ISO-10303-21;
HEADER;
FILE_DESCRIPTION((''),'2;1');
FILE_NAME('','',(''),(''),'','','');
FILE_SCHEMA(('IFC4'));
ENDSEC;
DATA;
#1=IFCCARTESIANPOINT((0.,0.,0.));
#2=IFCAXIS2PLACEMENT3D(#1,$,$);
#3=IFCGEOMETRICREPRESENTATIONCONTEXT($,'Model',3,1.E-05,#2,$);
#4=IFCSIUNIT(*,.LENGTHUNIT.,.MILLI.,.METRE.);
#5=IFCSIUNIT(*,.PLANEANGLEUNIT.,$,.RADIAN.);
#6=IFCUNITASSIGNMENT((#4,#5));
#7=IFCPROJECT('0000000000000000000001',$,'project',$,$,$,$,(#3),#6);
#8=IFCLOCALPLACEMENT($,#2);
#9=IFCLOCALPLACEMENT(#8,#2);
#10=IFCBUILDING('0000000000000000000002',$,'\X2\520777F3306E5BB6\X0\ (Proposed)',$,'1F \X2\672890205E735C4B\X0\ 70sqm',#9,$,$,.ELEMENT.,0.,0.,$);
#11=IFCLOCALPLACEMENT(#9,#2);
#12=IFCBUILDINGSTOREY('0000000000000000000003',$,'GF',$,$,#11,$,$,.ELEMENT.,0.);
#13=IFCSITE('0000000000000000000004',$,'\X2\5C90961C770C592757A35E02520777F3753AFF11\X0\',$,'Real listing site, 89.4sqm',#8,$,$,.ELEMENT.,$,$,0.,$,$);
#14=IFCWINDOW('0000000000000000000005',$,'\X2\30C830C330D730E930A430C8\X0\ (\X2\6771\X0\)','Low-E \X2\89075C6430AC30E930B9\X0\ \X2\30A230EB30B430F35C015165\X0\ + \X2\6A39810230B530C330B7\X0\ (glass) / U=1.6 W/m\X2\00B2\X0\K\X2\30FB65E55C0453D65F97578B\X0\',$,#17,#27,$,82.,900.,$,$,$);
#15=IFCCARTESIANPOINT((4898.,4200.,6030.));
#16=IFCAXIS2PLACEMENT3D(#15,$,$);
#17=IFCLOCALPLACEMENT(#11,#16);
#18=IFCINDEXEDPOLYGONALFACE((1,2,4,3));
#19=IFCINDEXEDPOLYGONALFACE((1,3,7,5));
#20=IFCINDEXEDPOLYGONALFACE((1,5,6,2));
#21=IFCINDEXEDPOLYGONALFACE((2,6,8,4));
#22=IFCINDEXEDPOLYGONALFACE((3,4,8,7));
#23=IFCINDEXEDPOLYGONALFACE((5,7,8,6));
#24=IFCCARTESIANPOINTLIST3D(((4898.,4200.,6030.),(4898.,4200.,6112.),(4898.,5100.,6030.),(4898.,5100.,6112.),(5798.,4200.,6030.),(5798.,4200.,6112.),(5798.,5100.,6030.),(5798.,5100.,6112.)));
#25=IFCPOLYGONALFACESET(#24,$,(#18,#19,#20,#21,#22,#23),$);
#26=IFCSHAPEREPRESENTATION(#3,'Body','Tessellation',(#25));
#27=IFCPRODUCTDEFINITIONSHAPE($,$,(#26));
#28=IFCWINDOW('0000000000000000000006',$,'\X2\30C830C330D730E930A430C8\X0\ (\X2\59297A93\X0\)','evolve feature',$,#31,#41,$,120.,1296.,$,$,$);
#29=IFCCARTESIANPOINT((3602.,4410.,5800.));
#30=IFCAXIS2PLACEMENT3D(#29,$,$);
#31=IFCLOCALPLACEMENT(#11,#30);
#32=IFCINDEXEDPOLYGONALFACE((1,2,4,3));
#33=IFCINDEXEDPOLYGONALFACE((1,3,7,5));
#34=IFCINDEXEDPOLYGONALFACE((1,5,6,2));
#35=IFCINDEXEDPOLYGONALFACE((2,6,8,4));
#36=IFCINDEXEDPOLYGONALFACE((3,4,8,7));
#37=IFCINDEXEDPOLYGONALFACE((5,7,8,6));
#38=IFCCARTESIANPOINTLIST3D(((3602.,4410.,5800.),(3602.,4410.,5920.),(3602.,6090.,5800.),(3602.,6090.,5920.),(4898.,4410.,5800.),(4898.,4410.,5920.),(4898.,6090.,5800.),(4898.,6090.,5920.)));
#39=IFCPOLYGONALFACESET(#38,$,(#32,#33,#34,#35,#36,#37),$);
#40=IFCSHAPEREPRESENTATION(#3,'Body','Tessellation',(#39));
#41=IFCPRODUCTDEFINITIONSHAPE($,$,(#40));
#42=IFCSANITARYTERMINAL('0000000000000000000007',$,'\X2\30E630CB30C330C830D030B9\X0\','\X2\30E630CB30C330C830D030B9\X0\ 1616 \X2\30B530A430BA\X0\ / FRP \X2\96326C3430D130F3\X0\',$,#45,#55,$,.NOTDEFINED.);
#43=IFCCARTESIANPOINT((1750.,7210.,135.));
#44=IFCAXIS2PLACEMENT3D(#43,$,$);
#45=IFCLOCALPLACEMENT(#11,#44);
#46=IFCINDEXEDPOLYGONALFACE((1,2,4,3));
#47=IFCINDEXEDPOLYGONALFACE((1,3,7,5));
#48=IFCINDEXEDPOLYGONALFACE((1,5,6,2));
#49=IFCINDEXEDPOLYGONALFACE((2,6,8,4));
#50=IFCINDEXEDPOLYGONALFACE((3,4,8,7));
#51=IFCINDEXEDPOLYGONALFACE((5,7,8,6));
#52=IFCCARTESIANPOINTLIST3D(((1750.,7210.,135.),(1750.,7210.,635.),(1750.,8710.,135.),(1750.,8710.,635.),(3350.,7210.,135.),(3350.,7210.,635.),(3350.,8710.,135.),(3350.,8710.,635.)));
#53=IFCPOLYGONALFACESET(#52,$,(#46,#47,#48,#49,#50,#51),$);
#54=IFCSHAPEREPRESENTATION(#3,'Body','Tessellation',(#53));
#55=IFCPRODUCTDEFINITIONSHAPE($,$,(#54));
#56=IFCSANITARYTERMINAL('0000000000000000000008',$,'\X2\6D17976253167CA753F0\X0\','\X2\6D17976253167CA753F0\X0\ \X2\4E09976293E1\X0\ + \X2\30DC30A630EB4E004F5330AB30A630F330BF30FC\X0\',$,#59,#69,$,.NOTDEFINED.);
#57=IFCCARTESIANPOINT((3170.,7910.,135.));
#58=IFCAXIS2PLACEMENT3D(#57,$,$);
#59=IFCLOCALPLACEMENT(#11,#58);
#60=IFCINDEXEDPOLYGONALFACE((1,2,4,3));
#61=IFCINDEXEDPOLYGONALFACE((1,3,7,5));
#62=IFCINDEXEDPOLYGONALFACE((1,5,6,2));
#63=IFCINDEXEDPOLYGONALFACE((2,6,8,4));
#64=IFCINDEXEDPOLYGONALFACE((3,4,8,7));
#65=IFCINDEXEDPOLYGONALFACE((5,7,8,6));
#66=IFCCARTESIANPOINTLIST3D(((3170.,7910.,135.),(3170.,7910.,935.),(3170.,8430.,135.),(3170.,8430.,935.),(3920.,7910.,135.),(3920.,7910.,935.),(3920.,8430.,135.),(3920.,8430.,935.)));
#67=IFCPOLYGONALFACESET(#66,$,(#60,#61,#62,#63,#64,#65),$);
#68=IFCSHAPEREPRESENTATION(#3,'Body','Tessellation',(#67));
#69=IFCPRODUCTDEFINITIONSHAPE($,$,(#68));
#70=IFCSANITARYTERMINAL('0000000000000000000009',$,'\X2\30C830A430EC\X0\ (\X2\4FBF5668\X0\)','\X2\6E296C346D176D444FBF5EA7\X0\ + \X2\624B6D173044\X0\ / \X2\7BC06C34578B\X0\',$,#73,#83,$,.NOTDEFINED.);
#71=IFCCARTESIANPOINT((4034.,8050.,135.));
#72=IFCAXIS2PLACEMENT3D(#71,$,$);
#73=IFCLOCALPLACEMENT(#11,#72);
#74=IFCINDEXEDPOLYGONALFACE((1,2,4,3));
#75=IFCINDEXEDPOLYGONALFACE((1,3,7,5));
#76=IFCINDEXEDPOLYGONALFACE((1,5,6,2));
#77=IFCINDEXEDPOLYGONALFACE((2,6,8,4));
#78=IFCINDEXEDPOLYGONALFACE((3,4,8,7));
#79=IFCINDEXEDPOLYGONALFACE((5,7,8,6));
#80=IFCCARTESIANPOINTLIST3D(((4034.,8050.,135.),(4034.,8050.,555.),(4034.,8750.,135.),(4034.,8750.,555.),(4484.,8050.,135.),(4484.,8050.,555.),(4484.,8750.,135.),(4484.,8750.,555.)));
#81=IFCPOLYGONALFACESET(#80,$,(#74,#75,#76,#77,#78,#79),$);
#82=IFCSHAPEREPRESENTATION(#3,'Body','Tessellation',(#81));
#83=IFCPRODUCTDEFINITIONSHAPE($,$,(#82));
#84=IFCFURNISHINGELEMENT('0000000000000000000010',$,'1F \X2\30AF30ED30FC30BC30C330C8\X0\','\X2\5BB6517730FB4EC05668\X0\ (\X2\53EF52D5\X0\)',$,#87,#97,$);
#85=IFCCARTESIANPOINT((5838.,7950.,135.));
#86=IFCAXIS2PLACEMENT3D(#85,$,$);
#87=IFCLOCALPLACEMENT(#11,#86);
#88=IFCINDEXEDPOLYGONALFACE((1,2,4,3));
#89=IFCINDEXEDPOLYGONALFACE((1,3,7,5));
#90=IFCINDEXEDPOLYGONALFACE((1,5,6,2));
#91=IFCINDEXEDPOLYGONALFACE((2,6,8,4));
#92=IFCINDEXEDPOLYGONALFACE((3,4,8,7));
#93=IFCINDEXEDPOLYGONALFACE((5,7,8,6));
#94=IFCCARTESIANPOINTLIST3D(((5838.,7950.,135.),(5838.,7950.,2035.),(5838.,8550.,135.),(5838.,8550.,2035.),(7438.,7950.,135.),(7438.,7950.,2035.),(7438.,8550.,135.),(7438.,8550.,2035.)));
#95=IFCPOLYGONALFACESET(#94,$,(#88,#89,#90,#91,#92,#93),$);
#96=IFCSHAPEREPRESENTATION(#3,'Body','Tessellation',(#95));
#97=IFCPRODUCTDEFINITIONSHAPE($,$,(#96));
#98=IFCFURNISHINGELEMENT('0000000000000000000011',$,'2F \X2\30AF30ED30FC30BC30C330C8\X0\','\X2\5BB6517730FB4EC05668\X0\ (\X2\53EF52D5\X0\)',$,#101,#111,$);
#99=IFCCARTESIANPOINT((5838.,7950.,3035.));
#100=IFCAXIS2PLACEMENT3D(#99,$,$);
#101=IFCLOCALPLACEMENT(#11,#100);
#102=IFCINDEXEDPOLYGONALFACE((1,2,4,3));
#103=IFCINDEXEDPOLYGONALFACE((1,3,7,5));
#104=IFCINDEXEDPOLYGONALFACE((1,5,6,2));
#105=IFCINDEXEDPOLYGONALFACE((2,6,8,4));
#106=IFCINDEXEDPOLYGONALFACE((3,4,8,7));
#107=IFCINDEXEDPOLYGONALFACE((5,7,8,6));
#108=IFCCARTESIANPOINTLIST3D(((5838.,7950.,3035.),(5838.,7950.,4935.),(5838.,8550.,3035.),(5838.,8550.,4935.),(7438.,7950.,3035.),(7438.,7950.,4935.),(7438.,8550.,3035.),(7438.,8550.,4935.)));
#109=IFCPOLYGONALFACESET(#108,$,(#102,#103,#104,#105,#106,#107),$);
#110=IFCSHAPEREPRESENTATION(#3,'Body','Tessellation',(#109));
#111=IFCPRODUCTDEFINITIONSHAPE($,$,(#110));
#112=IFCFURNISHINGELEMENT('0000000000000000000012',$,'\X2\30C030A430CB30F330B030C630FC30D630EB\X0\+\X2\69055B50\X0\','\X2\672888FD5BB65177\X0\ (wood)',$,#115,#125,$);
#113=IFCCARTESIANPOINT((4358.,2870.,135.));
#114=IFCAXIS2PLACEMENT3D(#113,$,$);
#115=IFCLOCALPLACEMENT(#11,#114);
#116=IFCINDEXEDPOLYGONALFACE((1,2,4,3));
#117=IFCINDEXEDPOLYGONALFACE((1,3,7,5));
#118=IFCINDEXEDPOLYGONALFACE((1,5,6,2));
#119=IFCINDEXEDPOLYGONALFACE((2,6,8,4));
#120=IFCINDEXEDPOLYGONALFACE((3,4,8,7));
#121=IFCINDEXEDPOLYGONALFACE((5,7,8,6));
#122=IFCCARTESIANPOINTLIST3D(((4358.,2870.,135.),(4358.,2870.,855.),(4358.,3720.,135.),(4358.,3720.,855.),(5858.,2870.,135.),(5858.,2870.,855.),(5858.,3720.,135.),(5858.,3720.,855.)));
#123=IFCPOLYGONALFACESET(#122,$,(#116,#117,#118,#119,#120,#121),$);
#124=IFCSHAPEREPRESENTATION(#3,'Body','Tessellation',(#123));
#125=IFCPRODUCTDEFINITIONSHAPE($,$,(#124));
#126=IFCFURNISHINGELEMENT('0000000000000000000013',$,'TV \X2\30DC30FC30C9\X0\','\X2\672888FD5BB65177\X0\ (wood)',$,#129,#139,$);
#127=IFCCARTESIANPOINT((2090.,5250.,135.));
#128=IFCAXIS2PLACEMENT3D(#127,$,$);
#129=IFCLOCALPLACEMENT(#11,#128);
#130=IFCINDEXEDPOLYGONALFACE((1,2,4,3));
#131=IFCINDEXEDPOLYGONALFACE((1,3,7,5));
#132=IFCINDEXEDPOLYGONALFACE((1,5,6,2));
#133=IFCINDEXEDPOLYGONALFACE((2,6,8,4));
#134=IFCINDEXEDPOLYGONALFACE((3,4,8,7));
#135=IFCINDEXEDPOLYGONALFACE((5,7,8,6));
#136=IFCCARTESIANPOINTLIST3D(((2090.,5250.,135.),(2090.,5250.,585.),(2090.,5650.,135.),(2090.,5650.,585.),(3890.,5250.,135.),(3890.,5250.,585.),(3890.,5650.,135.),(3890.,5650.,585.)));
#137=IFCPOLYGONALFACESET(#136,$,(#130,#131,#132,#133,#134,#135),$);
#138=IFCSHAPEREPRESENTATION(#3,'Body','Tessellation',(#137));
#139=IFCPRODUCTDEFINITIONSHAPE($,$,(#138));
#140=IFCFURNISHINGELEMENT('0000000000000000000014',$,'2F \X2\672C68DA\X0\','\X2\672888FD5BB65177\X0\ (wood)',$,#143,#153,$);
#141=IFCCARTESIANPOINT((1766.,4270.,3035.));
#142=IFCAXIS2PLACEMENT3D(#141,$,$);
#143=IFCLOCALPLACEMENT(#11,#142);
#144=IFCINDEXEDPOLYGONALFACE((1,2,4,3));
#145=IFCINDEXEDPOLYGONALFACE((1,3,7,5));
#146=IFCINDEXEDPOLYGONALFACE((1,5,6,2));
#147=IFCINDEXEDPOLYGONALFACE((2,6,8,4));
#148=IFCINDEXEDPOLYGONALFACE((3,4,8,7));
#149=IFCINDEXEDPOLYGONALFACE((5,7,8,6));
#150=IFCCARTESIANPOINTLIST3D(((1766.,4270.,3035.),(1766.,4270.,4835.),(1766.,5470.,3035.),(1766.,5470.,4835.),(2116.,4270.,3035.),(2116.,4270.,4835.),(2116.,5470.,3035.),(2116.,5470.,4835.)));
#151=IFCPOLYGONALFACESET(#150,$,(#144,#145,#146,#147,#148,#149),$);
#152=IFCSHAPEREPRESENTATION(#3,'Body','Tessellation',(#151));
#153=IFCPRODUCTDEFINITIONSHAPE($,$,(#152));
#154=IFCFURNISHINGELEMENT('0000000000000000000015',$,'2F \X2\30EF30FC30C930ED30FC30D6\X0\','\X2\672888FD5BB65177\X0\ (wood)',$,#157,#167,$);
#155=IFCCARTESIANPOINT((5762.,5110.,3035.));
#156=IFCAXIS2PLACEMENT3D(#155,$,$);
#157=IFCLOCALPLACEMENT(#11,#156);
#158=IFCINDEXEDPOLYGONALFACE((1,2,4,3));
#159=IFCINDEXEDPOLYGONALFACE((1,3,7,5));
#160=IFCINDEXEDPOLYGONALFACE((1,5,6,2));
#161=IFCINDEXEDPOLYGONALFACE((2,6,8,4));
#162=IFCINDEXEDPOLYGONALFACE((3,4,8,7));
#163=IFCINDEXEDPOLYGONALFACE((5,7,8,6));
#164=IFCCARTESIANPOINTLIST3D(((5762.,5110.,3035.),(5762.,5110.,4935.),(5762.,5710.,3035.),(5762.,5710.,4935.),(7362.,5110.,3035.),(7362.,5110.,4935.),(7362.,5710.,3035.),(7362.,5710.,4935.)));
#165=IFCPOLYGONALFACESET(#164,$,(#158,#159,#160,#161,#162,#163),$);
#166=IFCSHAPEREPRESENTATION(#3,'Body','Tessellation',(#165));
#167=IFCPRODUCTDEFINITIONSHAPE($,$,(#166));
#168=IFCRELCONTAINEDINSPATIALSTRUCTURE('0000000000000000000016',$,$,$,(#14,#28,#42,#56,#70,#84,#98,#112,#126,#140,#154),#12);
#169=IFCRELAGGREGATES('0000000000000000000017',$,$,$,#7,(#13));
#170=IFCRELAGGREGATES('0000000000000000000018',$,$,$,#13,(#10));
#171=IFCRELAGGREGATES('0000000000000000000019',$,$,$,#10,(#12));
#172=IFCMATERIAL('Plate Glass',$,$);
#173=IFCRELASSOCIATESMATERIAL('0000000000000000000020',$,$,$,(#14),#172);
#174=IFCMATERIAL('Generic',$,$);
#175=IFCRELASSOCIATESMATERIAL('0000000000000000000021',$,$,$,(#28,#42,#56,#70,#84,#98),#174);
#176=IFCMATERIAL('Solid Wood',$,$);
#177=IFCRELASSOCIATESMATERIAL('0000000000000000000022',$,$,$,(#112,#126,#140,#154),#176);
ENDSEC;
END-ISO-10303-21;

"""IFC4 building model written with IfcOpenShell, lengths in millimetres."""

from ifc_helpers import new_model, si_unit, frame, frame_2d, origin, place, context, project, spatial, rectangle, extrude, material, element, save


model = new_model("IFC4")

# Units and contexts
model_context = context("Model", 3, precision=1e-05, world=origin())
ifc_project = project(units=[si_unit("LENGTHUNIT", "METRE", prefix="MILLI"), si_unit("PLANEANGLEUNIT", "RADIAN")], contexts=[model_context])

# Site, building, storey
site_placement = place(None, origin())
site = spatial("IfcSite", under=ifc_project, at=site_placement, Name="岐阜県大垣市切石町１", ObjectType="Real listing site, 89.4sqm", CompositionType="ELEMENT", RefElevation=0.0)
building_placement = place(site_placement, origin())
building = spatial("IfcBuilding", under=site, at=building_placement, Name="切石の家 (Proposed)", ObjectType="1F 木造平屋 70sqm", CompositionType="ELEMENT", ElevationOfRefHeight=0.0, ElevationOfTerrain=0.0)
storey_placement = place(building_placement, origin())
storey = spatial("IfcBuildingStorey", under=building, at=storey_placement, Name="GF", CompositionType="ELEMENT", Elevation=0.0)

# Shared definitions
ifc_material_1 = material(Name="Solid Wood")
ifc_material_2 = material(Name="Plate Glass")

# Windows
window_1_placement = place(storey_placement, frame((4898.0, 4200.0, 6030.0)))
element("IfcWindow", 1, at=window_1_placement, inside=storey, material=ifc_material_2, Name="トップライト (東)", Description="Low-E 複層ガラス アルゴン封入 + 樹脂サッシ (glass) / U=1.6 W/m²K・日射取得型", OverallHeight=82.0, OverallWidth=900.0, context=model_context, shape_type="SweptSolid", body=[
    extrude(rectangle(XDim=900.0, YDim=900.0, at=frame_2d((450.0, 450.0))), frame((4898.0, 4200.0, 6030.0)), (0.0, 0.0, 1.0), 82.0),
])
ifc_material_3 = material(Name="Generic")
window_2_placement = place(storey_placement, frame((3602.0, 4410.0, 5800.0)))
element("IfcWindow", 2, at=window_2_placement, inside=storey, material=ifc_material_3, Name="トップライト (天窓)", Description="evolve feature", OverallHeight=120.0, OverallWidth=1296.0, context=model_context, shape_type="SweptSolid", body=[
    extrude(rectangle(XDim=1296.0, YDim=1680.0, at=frame_2d((648.0, 840.0))), frame((3602.0, 4410.0, 5800.0)), (0.0, 0.0, 1.0), 120.0),
])

# Sanitary terminals
sanitary_terminal_1_placement = place(storey_placement, frame((1750.0, 7210.0, 135.0)))
element("IfcSanitaryTerminal", 3, at=sanitary_terminal_1_placement, inside=storey, material=ifc_material_3, Name="ユニットバス", Description="ユニットバス 1616 サイズ / FRP 防水パン", PredefinedType="NOTDEFINED", context=model_context, shape_type="SweptSolid", body=[
    extrude(rectangle(XDim=1600.0, YDim=1500.0, at=frame_2d((800.0, 750.0))), frame((1750.0, 7210.0, 135.0)), (0.0, 0.0, 1.0), 500.0),
])
sanitary_terminal_2_placement = place(storey_placement, frame((3170.0, 7910.0, 135.0)))
element("IfcSanitaryTerminal", 4, at=sanitary_terminal_2_placement, inside=storey, material=ifc_material_3, Name="洗面化粧台", Description="洗面化粧台 三面鏡 + ボウル一体カウンター", PredefinedType="NOTDEFINED", context=model_context, shape_type="SweptSolid", body=[
    extrude(rectangle(XDim=750.0, YDim=520.0, at=frame_2d((375.0, 260.0))), frame((3170.0, 7910.0, 135.0)), (0.0, 0.0, 1.0), 800.0),
])
sanitary_terminal_3_placement = place(storey_placement, frame((4034.0, 8050.0, 135.0)))
element("IfcSanitaryTerminal", 5, at=sanitary_terminal_3_placement, inside=storey, material=ifc_material_3, Name="トイレ (便器)", Description="温水洗浄便座 + 手洗い / 節水型", PredefinedType="NOTDEFINED", context=model_context, shape_type="SweptSolid", body=[
    extrude(rectangle(XDim=450.0, YDim=700.0, at=frame_2d((225.0, 350.0))), frame((4034.0, 8050.0, 135.0)), (0.0, 0.0, 1.0), 420.0),
])

# Furnishing elements
furnishing_1_placement = place(storey_placement, frame((5838.0, 7950.0, 135.0)))
element("IfcFurnishingElement", 6, at=furnishing_1_placement, inside=storey, material=ifc_material_3, Name="1F クローゼット", Description="家具・什器 (可動)", context=model_context, shape_type="SweptSolid", body=[
    extrude(rectangle(XDim=1600.0, YDim=600.0, at=frame_2d((800.0, 300.0))), frame((5838.0, 7950.0, 135.0)), (0.0, 0.0, 1.0), 1900.0),
])
furnishing_2_placement = place(storey_placement, frame((5838.0, 7950.0, 3035.0)))
element("IfcFurnishingElement", 7, at=furnishing_2_placement, inside=storey, material=ifc_material_3, Name="2F クローゼット", Description="家具・什器 (可動)", context=model_context, shape_type="SweptSolid", body=[
    extrude(rectangle(XDim=1600.0, YDim=600.0, at=frame_2d((800.0, 300.0))), frame((5838.0, 7950.0, 3035.0)), (0.0, 0.0, 1.0), 1900.0),
])
furnishing_3_placement = place(storey_placement, frame((4358.0, 2870.0, 135.0)))
element("IfcFurnishingElement", 8, at=furnishing_3_placement, inside=storey, material=ifc_material_1, Name="ダイニングテーブル+椅子", Description="木製家具 (wood)", context=model_context, shape_type="SweptSolid", body=[
    extrude(rectangle(XDim=1500.0, YDim=850.0, at=frame_2d((750.0, 425.0))), frame((4358.0, 2870.0, 135.0)), (0.0, 0.0, 1.0), 720.0),
])
furnishing_4_placement = place(storey_placement, frame((2090.0, 5250.0, 135.0)))
element("IfcFurnishingElement", 9, at=furnishing_4_placement, inside=storey, material=ifc_material_1, Name="TV ボード", Description="木製家具 (wood)", context=model_context, shape_type="SweptSolid", body=[
    extrude(rectangle(XDim=1800.0, YDim=400.0, at=frame_2d((900.0, 200.0))), frame((2090.0, 5250.0, 135.0)), (0.0, 0.0, 1.0), 450.0),
])
furnishing_5_placement = place(storey_placement, frame((1766.0, 4270.0, 3035.0)))
element("IfcFurnishingElement", 10, at=furnishing_5_placement, inside=storey, material=ifc_material_1, Name="2F 本棚", Description="木製家具 (wood)", context=model_context, shape_type="SweptSolid", body=[
    extrude(rectangle(XDim=350.0, YDim=1200.0, at=frame_2d((175.0, 600.0))), frame((1766.0, 4270.0, 3035.0)), (0.0, 0.0, 1.0), 1800.0),
])
furnishing_6_placement = place(storey_placement, frame((5762.0, 5110.0, 3035.0)))
element("IfcFurnishingElement", 11, at=furnishing_6_placement, inside=storey, material=ifc_material_1, Name="2F ワードローブ", Description="木製家具 (wood)", context=model_context, shape_type="SweptSolid", body=[
    extrude(rectangle(XDim=1600.0, YDim=600.0, at=frame_2d((800.0, 300.0))), frame((5762.0, 5110.0, 3035.0)), (0.0, 0.0, 1.0), 1900.0),
])

save(model, "model.ifc")
